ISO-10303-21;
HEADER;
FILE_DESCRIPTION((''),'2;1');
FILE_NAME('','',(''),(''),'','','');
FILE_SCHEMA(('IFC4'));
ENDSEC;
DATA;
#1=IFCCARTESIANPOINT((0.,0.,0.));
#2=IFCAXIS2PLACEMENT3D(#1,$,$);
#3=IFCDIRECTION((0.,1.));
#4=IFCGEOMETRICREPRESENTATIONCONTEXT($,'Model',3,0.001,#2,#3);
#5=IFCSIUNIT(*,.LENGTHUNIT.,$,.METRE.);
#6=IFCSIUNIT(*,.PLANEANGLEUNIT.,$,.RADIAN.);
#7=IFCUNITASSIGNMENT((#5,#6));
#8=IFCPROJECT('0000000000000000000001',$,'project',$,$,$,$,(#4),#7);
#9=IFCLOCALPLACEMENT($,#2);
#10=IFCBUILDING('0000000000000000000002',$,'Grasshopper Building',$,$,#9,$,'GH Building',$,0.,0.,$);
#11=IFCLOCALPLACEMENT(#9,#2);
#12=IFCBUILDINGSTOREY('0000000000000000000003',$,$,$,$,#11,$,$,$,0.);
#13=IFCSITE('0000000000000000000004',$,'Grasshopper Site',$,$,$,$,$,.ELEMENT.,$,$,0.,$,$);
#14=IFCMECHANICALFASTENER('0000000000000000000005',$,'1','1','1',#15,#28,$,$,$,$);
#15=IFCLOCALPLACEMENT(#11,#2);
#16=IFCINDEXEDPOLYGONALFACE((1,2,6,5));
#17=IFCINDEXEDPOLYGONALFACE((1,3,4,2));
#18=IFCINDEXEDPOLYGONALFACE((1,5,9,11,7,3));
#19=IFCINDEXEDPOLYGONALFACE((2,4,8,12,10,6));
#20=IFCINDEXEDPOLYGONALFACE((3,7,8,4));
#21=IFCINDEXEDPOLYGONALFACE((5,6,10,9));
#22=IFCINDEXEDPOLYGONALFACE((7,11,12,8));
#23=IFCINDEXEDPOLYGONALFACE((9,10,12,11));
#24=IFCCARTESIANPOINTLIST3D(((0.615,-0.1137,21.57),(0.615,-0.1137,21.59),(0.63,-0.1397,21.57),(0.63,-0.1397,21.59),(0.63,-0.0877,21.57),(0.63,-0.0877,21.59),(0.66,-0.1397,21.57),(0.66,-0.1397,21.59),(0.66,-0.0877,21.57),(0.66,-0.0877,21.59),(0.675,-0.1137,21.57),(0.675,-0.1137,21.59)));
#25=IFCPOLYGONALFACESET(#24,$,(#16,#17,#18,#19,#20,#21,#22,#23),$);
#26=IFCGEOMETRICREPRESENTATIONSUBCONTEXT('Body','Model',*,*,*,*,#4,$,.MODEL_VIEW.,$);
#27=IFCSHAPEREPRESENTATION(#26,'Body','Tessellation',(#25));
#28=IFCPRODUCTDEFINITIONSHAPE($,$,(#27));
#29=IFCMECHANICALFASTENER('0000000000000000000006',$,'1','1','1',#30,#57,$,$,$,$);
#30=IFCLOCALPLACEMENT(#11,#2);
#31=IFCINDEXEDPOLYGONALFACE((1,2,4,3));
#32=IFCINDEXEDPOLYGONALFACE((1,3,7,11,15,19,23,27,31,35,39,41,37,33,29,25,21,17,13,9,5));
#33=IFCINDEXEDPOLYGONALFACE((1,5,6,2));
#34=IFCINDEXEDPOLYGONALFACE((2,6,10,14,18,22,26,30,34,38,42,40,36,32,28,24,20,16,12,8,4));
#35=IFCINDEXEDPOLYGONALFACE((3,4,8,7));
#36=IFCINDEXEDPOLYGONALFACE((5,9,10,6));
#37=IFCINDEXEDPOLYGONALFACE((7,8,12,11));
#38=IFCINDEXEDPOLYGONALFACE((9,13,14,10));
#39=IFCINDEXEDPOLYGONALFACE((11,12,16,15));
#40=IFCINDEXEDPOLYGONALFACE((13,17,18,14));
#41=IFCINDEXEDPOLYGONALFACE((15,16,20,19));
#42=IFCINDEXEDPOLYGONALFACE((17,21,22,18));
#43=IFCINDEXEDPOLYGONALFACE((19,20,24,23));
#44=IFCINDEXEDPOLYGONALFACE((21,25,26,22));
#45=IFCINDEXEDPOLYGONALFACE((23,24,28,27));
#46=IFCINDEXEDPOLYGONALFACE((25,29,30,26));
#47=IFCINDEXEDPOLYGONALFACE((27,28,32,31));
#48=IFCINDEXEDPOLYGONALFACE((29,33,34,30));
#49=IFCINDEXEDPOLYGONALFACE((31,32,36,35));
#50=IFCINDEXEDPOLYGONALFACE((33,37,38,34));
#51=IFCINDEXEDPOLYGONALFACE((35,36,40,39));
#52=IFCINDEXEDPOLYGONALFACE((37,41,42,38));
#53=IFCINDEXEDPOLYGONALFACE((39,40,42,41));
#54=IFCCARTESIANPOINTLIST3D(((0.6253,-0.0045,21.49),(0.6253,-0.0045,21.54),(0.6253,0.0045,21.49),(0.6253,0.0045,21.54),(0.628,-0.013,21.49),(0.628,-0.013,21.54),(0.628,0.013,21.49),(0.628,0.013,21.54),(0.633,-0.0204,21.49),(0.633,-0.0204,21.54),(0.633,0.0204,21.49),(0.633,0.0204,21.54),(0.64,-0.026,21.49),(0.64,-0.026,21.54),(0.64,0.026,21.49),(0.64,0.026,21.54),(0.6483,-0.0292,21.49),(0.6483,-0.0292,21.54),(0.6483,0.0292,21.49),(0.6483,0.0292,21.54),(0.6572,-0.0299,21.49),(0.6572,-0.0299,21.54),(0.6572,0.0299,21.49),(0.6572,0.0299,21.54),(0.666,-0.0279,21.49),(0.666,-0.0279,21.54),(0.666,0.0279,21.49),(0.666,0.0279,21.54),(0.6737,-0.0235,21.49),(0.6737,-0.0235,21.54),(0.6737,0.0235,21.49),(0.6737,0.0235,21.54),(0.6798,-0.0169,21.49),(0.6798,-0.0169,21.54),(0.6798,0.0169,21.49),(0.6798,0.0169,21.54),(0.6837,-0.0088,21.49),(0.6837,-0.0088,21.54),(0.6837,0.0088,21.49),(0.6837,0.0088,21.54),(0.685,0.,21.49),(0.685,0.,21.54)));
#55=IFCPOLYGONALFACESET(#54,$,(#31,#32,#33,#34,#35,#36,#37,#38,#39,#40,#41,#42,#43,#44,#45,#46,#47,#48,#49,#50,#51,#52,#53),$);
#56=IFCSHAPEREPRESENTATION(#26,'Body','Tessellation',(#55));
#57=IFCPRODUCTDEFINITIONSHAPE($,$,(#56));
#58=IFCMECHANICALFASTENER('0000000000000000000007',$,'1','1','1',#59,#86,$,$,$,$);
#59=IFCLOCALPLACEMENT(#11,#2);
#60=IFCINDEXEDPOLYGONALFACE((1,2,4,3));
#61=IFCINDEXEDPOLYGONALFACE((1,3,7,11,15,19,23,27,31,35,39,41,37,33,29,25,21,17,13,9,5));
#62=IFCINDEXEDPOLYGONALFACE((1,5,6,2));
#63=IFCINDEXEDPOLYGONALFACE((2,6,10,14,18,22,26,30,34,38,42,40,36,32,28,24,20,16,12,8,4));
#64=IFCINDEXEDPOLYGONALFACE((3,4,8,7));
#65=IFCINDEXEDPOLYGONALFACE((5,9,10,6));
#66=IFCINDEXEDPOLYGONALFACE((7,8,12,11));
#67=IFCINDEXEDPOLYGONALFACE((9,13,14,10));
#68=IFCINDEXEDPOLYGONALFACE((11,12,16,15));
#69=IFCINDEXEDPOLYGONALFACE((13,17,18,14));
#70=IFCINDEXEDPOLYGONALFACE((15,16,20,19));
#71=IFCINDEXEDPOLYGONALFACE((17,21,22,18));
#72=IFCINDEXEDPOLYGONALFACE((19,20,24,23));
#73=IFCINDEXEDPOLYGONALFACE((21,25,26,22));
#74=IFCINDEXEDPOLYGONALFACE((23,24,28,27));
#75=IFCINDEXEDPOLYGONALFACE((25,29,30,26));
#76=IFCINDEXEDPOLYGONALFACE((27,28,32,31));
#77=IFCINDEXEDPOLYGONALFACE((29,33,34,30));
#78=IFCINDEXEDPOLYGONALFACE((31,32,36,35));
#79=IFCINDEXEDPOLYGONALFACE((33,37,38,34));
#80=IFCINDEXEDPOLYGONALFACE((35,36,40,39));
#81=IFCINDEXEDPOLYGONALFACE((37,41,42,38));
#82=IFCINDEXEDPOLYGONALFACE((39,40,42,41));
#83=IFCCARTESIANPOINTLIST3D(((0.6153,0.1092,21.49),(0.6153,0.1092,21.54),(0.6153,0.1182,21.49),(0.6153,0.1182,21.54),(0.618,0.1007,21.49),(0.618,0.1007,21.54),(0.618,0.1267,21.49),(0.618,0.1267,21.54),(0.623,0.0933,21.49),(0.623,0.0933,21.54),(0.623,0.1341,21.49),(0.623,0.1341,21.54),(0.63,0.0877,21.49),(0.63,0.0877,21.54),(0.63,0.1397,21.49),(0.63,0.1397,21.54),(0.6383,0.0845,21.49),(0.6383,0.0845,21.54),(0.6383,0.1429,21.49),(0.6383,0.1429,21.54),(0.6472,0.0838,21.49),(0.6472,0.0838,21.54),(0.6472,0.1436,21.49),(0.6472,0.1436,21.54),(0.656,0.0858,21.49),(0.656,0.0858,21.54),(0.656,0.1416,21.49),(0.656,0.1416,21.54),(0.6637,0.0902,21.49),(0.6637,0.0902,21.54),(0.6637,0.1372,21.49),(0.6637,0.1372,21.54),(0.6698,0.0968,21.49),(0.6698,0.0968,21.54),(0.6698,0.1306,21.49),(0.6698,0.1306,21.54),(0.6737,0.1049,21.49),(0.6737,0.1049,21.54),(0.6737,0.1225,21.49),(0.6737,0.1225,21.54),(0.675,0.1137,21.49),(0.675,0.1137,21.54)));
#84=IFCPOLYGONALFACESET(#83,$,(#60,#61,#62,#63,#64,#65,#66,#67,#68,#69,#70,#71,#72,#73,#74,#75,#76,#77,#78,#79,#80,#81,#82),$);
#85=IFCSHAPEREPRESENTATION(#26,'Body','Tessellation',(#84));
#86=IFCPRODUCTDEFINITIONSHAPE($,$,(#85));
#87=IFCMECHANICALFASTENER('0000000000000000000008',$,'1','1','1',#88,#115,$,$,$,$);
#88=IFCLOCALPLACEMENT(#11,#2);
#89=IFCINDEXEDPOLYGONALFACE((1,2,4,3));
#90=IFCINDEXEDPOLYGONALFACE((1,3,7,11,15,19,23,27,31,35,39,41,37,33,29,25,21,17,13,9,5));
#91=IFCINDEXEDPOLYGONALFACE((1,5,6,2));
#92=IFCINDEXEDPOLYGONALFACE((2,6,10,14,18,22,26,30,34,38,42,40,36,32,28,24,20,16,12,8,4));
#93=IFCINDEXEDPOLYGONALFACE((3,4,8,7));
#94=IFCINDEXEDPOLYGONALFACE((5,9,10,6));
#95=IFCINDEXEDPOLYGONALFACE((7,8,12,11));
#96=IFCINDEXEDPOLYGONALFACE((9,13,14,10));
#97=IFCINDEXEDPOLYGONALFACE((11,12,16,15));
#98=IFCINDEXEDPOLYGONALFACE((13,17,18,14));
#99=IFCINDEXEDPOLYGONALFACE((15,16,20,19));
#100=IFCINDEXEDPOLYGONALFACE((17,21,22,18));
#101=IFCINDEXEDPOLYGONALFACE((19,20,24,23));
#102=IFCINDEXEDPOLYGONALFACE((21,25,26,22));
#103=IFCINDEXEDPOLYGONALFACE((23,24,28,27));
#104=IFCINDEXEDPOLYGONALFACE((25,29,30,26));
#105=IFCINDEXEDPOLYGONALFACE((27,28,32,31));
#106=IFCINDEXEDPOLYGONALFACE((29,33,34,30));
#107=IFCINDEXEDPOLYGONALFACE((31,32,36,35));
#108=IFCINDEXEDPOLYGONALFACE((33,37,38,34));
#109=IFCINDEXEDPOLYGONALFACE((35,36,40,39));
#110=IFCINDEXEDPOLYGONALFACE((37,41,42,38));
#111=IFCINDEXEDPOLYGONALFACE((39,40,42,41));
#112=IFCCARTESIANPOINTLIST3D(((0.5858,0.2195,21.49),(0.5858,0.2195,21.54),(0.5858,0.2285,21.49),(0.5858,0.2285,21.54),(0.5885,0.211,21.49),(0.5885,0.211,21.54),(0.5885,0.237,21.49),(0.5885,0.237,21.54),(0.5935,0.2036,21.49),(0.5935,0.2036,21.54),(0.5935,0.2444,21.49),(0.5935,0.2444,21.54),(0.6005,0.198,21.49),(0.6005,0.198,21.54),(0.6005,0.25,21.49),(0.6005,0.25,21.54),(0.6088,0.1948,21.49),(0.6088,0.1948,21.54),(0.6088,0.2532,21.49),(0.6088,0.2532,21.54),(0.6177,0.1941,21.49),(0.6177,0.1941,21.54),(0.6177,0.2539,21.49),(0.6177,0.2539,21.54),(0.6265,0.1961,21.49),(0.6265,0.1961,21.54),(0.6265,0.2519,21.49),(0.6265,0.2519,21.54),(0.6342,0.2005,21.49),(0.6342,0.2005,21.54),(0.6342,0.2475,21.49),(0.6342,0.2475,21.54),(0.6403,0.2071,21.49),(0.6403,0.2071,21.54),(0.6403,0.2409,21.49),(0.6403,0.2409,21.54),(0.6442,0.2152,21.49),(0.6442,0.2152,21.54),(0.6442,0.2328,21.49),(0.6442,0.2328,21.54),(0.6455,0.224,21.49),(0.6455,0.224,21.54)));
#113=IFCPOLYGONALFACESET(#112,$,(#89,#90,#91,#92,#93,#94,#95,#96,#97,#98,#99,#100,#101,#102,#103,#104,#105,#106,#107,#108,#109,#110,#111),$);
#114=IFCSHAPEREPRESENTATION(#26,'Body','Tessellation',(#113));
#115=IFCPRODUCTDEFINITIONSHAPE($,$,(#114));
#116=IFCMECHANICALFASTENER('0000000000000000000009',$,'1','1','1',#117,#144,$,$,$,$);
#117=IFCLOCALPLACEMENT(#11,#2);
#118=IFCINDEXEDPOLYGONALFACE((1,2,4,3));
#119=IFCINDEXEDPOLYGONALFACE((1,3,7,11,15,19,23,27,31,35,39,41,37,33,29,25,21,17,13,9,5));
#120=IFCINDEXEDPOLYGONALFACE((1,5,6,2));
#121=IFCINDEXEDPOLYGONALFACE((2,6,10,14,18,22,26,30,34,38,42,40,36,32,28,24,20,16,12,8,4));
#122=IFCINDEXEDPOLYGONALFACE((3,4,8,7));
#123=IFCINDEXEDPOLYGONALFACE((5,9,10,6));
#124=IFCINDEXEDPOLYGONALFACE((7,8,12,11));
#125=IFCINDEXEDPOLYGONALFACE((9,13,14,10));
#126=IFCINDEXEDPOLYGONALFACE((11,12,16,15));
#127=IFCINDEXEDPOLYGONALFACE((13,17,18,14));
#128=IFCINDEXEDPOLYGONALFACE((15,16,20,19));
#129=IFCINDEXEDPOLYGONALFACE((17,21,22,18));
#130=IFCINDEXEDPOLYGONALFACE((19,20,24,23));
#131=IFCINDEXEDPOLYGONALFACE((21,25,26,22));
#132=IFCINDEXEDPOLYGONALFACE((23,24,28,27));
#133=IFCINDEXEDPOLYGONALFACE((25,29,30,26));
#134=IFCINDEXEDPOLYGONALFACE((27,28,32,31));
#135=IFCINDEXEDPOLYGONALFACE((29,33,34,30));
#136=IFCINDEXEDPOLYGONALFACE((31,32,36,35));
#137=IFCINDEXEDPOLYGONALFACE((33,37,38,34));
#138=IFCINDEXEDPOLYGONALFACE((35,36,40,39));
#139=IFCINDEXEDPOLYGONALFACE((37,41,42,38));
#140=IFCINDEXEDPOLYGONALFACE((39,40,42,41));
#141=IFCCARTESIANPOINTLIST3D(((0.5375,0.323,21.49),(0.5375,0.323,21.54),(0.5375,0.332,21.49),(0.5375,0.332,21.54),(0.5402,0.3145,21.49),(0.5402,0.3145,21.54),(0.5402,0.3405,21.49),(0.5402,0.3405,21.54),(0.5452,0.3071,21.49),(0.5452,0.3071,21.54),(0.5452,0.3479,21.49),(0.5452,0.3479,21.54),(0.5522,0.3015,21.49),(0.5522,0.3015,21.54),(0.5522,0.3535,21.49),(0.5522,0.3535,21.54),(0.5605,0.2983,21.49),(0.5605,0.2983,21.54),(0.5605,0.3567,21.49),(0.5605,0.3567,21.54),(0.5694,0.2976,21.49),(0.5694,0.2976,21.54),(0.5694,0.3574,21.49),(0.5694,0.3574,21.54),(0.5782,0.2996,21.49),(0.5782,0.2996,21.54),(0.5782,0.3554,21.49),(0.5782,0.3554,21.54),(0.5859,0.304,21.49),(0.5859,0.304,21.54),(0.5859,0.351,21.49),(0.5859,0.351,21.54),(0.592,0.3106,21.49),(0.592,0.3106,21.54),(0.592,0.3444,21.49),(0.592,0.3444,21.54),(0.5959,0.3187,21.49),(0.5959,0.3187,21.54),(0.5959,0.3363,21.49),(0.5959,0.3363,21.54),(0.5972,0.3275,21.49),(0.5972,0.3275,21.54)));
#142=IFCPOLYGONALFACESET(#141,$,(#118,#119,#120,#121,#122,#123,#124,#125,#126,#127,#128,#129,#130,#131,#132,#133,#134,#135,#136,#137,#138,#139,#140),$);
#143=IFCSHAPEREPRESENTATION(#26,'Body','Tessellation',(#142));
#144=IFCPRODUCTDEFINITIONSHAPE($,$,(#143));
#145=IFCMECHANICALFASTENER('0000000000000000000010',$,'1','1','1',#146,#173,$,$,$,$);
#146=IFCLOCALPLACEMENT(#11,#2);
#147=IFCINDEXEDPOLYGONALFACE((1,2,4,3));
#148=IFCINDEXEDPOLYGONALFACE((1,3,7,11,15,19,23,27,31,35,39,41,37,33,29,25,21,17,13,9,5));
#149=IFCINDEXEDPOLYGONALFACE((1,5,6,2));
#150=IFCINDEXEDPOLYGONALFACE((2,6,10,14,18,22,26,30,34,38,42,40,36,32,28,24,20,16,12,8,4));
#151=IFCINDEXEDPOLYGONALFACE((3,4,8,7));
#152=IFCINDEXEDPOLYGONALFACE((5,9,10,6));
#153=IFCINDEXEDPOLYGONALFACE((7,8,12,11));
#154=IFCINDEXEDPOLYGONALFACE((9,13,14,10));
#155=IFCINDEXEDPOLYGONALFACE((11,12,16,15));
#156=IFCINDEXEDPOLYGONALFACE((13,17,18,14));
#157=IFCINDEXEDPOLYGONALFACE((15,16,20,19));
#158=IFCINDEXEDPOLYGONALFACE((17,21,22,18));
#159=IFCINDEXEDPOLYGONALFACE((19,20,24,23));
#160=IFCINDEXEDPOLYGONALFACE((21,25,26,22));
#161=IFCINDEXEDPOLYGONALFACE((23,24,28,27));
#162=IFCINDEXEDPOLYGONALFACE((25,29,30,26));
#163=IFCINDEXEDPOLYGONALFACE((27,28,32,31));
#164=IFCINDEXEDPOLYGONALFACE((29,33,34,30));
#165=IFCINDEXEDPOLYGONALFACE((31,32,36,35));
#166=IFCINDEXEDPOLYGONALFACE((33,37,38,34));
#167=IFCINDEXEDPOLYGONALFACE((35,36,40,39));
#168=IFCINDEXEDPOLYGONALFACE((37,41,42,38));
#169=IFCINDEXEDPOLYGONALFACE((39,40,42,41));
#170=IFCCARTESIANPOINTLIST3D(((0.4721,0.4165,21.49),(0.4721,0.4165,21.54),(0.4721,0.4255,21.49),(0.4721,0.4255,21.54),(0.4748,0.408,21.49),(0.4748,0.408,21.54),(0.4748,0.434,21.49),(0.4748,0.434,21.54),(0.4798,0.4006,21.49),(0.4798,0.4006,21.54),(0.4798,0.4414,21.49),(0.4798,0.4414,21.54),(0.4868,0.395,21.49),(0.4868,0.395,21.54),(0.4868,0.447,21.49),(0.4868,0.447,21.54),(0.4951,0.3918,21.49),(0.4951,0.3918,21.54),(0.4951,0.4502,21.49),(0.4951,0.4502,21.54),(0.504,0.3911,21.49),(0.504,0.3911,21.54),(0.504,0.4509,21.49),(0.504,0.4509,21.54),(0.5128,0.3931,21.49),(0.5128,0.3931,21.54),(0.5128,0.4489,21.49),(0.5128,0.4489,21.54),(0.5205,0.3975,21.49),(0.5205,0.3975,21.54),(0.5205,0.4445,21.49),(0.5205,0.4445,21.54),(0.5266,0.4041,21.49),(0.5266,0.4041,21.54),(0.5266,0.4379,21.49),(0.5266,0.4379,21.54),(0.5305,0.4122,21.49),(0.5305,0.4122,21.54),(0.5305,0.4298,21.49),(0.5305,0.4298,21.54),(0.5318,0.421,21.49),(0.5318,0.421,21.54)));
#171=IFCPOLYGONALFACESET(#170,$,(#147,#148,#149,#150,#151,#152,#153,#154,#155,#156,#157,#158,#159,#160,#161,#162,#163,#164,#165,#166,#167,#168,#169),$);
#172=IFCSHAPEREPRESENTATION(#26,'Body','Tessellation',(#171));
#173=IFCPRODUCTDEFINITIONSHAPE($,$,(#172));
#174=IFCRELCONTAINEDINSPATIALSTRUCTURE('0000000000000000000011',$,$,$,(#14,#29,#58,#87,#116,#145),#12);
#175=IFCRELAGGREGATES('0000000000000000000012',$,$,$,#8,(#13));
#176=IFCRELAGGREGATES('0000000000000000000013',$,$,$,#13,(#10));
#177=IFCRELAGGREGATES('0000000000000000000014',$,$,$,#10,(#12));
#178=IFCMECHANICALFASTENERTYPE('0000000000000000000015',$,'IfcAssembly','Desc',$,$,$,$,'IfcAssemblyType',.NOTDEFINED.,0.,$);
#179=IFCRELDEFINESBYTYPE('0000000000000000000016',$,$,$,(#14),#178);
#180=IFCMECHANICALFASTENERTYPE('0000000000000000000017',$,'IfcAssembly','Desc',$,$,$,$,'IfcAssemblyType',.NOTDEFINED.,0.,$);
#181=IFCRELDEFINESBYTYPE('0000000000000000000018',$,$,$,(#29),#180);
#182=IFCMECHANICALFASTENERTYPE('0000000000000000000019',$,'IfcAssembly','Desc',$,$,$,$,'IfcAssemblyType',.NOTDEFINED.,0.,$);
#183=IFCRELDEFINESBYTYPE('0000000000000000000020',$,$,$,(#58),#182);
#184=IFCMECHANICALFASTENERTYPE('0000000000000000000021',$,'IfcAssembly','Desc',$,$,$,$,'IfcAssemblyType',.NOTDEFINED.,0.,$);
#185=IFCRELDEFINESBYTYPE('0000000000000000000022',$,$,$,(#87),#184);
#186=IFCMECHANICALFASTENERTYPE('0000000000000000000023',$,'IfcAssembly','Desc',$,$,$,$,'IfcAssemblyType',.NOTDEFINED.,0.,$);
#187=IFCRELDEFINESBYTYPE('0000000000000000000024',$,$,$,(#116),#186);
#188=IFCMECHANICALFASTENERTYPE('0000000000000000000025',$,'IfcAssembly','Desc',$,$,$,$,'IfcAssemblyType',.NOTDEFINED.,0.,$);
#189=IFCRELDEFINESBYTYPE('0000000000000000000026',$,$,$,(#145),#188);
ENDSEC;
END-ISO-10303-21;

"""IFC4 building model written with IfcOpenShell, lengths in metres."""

from ifc_helpers import new_model, si_unit, direction, frame, origin, place, context, subcontext, project, spatial, indexed_curve, circle, outline, extrude, source, transform, mapped, type_object, type_shapes, element, save


model = new_model("IFC4")

# Units and contexts
model_context = context("Model", 3, precision=0.001, world=origin(), true_north=direction((0.0, 1.0)))
body_context = subcontext(model_context, "Body", "Model", "MODEL_VIEW")
ifc_project = project(units=[si_unit("LENGTHUNIT", "METRE"), si_unit("PLANEANGLEUNIT", "RADIAN")], contexts=[model_context])

# Site, building, storey
site = spatial("IfcSite", under=ifc_project, Name="Grasshopper Site", CompositionType="ELEMENT", RefElevation=0.0)
building_placement = place(None, origin())
building = spatial("IfcBuilding", under=site, at=building_placement, Name="Grasshopper Building", LongName="GH Building", ElevationOfRefHeight=0.0, ElevationOfTerrain=0.0)
storey_placement = place(building_placement, origin())
storey = spatial("IfcBuildingStorey", under=building, at=storey_placement, Elevation=0.0)

# Mechanical fasteners
mechanical_fastener_type_1 = type_object("IfcMechanicalFastenerType", Name="IfcAssembly", Description="Desc", ElementType="IfcAssemblyType", NominalDiameter=0.0)
shared_shape_1 = source(origin(), body_context, "Body", "SweptSolid", [
    extrude(outline(indexed_curve([(0.03, 0.0), (0.015, 0.026), (-0.015, 0.026), (-0.03, 0.0), (-0.015, -0.026), (0.015, -0.026), (0.03, 0.0)])), frame((0.645, -0.1137, 21.57)), (0.0, 0.0, 1.0), 0.02),
])
type_shapes(mechanical_fastener_type_1, [shared_shape_1])
mechanical_fastener_1_placement = place(storey_placement, origin())
element("IfcMechanicalFastener", 1, at=mechanical_fastener_1_placement, inside=storey, type_object=mechanical_fastener_type_1, Name="1", Description="1", ObjectType="1", context=body_context, shape_type="MappedRepresentation", body=[
    mapped(shared_shape_1, transform((0.0, 0.0, 0.0), scale=1.0)),
])
mechanical_fastener_type_2 = type_object("IfcMechanicalFastenerType", Name="IfcAssembly", Description="Desc", ElementType="IfcAssemblyType", NominalDiameter=0.0)
shared_shape_2 = source(origin(), body_context, "Body", "SweptSolid", [
    extrude(circle(Radius=0.03), frame((0.655, 0.0, 21.54), z_axis=(0.0, 0.0, -1.0), x_axis=(1.0, 0.0, 0.0)), (0.0, 0.0, 1.0), 0.05),
])
type_shapes(mechanical_fastener_type_2, [shared_shape_2])
mechanical_fastener_2_placement = place(storey_placement, origin())
element("IfcMechanicalFastener", 2, at=mechanical_fastener_2_placement, inside=storey, type_object=mechanical_fastener_type_2, Name="1", Description="1", ObjectType="1", context=body_context, shape_type="MappedRepresentation", body=[
    mapped(shared_shape_2, transform((0.0, 0.0, 0.0), scale=1.0)),
])
mechanical_fastener_type_3 = type_object("IfcMechanicalFastenerType", Name="IfcAssembly", Description="Desc", ElementType="IfcAssemblyType", NominalDiameter=0.0)
shared_shape_3 = source(origin(), body_context, "Body", "SweptSolid", [
    extrude(circle(Radius=0.03), frame((0.645, 0.1137, 21.54), z_axis=(0.0, 0.0, -1.0), x_axis=(1.0, 0.0, 0.0)), (0.0, 0.0, 1.0), 0.05),
])
type_shapes(mechanical_fastener_type_3, [shared_shape_3])
mechanical_fastener_3_placement = place(storey_placement, origin())
element("IfcMechanicalFastener", 3, at=mechanical_fastener_3_placement, inside=storey, type_object=mechanical_fastener_type_3, Name="1", Description="1", ObjectType="1", context=body_context, shape_type="MappedRepresentation", body=[
    mapped(shared_shape_3, transform((0.0, 0.0, 0.0), scale=1.0)),
])
mechanical_fastener_type_4 = type_object("IfcMechanicalFastenerType", Name="IfcAssembly", Description="Desc", ElementType="IfcAssemblyType", NominalDiameter=0.0)
shared_shape_4 = source(origin(), body_context, "Body", "SweptSolid", [
    extrude(circle(Radius=0.03), frame((0.6155, 0.224, 21.54), z_axis=(0.0, 0.0, -1.0), x_axis=(1.0, 0.0, 0.0)), (0.0, 0.0, 1.0), 0.05),
])
type_shapes(mechanical_fastener_type_4, [shared_shape_4])
mechanical_fastener_4_placement = place(storey_placement, origin())
element("IfcMechanicalFastener", 4, at=mechanical_fastener_4_placement, inside=storey, type_object=mechanical_fastener_type_4, Name="1", Description="1", ObjectType="1", context=body_context, shape_type="MappedRepresentation", body=[
    mapped(shared_shape_4, transform((0.0, 0.0, 0.0), scale=1.0)),
])
mechanical_fastener_type_5 = type_object("IfcMechanicalFastenerType", Name="IfcAssembly", Description="Desc", ElementType="IfcAssemblyType", NominalDiameter=0.0)
shared_shape_5 = source(origin(), body_context, "Body", "SweptSolid", [
    extrude(circle(Radius=0.03), frame((0.5672, 0.3275, 21.54), z_axis=(0.0, 0.0, -1.0), x_axis=(1.0, 0.0, 0.0)), (0.0, 0.0, 1.0), 0.05),
])
type_shapes(mechanical_fastener_type_5, [shared_shape_5])
mechanical_fastener_5_placement = place(storey_placement, origin())
element("IfcMechanicalFastener", 5, at=mechanical_fastener_5_placement, inside=storey, type_object=mechanical_fastener_type_5, Name="1", Description="1", ObjectType="1", context=body_context, shape_type="MappedRepresentation", body=[
    mapped(shared_shape_5, transform((0.0, 0.0, 0.0), scale=1.0)),
])
mechanical_fastener_type_6 = type_object("IfcMechanicalFastenerType", Name="IfcAssembly", Description="Desc", ElementType="IfcAssemblyType", NominalDiameter=0.0)
shared_shape_6 = source(origin(), body_context, "Body", "SweptSolid", [
    extrude(circle(Radius=0.03), frame((0.5018, 0.421, 21.54), z_axis=(0.0, 0.0, -1.0), x_axis=(1.0, 0.0, 0.0)), (0.0, 0.0, 1.0), 0.05),
])
type_shapes(mechanical_fastener_type_6, [shared_shape_6])
mechanical_fastener_6_placement = place(storey_placement, origin())
element("IfcMechanicalFastener", 6, at=mechanical_fastener_6_placement, inside=storey, type_object=mechanical_fastener_type_6, Name="1", Description="1", ObjectType="1", context=body_context, shape_type="MappedRepresentation", body=[
    mapped(shared_shape_6, transform((0.0, 0.0, 0.0), scale=1.0)),
])

save(model, "model.ifc")
